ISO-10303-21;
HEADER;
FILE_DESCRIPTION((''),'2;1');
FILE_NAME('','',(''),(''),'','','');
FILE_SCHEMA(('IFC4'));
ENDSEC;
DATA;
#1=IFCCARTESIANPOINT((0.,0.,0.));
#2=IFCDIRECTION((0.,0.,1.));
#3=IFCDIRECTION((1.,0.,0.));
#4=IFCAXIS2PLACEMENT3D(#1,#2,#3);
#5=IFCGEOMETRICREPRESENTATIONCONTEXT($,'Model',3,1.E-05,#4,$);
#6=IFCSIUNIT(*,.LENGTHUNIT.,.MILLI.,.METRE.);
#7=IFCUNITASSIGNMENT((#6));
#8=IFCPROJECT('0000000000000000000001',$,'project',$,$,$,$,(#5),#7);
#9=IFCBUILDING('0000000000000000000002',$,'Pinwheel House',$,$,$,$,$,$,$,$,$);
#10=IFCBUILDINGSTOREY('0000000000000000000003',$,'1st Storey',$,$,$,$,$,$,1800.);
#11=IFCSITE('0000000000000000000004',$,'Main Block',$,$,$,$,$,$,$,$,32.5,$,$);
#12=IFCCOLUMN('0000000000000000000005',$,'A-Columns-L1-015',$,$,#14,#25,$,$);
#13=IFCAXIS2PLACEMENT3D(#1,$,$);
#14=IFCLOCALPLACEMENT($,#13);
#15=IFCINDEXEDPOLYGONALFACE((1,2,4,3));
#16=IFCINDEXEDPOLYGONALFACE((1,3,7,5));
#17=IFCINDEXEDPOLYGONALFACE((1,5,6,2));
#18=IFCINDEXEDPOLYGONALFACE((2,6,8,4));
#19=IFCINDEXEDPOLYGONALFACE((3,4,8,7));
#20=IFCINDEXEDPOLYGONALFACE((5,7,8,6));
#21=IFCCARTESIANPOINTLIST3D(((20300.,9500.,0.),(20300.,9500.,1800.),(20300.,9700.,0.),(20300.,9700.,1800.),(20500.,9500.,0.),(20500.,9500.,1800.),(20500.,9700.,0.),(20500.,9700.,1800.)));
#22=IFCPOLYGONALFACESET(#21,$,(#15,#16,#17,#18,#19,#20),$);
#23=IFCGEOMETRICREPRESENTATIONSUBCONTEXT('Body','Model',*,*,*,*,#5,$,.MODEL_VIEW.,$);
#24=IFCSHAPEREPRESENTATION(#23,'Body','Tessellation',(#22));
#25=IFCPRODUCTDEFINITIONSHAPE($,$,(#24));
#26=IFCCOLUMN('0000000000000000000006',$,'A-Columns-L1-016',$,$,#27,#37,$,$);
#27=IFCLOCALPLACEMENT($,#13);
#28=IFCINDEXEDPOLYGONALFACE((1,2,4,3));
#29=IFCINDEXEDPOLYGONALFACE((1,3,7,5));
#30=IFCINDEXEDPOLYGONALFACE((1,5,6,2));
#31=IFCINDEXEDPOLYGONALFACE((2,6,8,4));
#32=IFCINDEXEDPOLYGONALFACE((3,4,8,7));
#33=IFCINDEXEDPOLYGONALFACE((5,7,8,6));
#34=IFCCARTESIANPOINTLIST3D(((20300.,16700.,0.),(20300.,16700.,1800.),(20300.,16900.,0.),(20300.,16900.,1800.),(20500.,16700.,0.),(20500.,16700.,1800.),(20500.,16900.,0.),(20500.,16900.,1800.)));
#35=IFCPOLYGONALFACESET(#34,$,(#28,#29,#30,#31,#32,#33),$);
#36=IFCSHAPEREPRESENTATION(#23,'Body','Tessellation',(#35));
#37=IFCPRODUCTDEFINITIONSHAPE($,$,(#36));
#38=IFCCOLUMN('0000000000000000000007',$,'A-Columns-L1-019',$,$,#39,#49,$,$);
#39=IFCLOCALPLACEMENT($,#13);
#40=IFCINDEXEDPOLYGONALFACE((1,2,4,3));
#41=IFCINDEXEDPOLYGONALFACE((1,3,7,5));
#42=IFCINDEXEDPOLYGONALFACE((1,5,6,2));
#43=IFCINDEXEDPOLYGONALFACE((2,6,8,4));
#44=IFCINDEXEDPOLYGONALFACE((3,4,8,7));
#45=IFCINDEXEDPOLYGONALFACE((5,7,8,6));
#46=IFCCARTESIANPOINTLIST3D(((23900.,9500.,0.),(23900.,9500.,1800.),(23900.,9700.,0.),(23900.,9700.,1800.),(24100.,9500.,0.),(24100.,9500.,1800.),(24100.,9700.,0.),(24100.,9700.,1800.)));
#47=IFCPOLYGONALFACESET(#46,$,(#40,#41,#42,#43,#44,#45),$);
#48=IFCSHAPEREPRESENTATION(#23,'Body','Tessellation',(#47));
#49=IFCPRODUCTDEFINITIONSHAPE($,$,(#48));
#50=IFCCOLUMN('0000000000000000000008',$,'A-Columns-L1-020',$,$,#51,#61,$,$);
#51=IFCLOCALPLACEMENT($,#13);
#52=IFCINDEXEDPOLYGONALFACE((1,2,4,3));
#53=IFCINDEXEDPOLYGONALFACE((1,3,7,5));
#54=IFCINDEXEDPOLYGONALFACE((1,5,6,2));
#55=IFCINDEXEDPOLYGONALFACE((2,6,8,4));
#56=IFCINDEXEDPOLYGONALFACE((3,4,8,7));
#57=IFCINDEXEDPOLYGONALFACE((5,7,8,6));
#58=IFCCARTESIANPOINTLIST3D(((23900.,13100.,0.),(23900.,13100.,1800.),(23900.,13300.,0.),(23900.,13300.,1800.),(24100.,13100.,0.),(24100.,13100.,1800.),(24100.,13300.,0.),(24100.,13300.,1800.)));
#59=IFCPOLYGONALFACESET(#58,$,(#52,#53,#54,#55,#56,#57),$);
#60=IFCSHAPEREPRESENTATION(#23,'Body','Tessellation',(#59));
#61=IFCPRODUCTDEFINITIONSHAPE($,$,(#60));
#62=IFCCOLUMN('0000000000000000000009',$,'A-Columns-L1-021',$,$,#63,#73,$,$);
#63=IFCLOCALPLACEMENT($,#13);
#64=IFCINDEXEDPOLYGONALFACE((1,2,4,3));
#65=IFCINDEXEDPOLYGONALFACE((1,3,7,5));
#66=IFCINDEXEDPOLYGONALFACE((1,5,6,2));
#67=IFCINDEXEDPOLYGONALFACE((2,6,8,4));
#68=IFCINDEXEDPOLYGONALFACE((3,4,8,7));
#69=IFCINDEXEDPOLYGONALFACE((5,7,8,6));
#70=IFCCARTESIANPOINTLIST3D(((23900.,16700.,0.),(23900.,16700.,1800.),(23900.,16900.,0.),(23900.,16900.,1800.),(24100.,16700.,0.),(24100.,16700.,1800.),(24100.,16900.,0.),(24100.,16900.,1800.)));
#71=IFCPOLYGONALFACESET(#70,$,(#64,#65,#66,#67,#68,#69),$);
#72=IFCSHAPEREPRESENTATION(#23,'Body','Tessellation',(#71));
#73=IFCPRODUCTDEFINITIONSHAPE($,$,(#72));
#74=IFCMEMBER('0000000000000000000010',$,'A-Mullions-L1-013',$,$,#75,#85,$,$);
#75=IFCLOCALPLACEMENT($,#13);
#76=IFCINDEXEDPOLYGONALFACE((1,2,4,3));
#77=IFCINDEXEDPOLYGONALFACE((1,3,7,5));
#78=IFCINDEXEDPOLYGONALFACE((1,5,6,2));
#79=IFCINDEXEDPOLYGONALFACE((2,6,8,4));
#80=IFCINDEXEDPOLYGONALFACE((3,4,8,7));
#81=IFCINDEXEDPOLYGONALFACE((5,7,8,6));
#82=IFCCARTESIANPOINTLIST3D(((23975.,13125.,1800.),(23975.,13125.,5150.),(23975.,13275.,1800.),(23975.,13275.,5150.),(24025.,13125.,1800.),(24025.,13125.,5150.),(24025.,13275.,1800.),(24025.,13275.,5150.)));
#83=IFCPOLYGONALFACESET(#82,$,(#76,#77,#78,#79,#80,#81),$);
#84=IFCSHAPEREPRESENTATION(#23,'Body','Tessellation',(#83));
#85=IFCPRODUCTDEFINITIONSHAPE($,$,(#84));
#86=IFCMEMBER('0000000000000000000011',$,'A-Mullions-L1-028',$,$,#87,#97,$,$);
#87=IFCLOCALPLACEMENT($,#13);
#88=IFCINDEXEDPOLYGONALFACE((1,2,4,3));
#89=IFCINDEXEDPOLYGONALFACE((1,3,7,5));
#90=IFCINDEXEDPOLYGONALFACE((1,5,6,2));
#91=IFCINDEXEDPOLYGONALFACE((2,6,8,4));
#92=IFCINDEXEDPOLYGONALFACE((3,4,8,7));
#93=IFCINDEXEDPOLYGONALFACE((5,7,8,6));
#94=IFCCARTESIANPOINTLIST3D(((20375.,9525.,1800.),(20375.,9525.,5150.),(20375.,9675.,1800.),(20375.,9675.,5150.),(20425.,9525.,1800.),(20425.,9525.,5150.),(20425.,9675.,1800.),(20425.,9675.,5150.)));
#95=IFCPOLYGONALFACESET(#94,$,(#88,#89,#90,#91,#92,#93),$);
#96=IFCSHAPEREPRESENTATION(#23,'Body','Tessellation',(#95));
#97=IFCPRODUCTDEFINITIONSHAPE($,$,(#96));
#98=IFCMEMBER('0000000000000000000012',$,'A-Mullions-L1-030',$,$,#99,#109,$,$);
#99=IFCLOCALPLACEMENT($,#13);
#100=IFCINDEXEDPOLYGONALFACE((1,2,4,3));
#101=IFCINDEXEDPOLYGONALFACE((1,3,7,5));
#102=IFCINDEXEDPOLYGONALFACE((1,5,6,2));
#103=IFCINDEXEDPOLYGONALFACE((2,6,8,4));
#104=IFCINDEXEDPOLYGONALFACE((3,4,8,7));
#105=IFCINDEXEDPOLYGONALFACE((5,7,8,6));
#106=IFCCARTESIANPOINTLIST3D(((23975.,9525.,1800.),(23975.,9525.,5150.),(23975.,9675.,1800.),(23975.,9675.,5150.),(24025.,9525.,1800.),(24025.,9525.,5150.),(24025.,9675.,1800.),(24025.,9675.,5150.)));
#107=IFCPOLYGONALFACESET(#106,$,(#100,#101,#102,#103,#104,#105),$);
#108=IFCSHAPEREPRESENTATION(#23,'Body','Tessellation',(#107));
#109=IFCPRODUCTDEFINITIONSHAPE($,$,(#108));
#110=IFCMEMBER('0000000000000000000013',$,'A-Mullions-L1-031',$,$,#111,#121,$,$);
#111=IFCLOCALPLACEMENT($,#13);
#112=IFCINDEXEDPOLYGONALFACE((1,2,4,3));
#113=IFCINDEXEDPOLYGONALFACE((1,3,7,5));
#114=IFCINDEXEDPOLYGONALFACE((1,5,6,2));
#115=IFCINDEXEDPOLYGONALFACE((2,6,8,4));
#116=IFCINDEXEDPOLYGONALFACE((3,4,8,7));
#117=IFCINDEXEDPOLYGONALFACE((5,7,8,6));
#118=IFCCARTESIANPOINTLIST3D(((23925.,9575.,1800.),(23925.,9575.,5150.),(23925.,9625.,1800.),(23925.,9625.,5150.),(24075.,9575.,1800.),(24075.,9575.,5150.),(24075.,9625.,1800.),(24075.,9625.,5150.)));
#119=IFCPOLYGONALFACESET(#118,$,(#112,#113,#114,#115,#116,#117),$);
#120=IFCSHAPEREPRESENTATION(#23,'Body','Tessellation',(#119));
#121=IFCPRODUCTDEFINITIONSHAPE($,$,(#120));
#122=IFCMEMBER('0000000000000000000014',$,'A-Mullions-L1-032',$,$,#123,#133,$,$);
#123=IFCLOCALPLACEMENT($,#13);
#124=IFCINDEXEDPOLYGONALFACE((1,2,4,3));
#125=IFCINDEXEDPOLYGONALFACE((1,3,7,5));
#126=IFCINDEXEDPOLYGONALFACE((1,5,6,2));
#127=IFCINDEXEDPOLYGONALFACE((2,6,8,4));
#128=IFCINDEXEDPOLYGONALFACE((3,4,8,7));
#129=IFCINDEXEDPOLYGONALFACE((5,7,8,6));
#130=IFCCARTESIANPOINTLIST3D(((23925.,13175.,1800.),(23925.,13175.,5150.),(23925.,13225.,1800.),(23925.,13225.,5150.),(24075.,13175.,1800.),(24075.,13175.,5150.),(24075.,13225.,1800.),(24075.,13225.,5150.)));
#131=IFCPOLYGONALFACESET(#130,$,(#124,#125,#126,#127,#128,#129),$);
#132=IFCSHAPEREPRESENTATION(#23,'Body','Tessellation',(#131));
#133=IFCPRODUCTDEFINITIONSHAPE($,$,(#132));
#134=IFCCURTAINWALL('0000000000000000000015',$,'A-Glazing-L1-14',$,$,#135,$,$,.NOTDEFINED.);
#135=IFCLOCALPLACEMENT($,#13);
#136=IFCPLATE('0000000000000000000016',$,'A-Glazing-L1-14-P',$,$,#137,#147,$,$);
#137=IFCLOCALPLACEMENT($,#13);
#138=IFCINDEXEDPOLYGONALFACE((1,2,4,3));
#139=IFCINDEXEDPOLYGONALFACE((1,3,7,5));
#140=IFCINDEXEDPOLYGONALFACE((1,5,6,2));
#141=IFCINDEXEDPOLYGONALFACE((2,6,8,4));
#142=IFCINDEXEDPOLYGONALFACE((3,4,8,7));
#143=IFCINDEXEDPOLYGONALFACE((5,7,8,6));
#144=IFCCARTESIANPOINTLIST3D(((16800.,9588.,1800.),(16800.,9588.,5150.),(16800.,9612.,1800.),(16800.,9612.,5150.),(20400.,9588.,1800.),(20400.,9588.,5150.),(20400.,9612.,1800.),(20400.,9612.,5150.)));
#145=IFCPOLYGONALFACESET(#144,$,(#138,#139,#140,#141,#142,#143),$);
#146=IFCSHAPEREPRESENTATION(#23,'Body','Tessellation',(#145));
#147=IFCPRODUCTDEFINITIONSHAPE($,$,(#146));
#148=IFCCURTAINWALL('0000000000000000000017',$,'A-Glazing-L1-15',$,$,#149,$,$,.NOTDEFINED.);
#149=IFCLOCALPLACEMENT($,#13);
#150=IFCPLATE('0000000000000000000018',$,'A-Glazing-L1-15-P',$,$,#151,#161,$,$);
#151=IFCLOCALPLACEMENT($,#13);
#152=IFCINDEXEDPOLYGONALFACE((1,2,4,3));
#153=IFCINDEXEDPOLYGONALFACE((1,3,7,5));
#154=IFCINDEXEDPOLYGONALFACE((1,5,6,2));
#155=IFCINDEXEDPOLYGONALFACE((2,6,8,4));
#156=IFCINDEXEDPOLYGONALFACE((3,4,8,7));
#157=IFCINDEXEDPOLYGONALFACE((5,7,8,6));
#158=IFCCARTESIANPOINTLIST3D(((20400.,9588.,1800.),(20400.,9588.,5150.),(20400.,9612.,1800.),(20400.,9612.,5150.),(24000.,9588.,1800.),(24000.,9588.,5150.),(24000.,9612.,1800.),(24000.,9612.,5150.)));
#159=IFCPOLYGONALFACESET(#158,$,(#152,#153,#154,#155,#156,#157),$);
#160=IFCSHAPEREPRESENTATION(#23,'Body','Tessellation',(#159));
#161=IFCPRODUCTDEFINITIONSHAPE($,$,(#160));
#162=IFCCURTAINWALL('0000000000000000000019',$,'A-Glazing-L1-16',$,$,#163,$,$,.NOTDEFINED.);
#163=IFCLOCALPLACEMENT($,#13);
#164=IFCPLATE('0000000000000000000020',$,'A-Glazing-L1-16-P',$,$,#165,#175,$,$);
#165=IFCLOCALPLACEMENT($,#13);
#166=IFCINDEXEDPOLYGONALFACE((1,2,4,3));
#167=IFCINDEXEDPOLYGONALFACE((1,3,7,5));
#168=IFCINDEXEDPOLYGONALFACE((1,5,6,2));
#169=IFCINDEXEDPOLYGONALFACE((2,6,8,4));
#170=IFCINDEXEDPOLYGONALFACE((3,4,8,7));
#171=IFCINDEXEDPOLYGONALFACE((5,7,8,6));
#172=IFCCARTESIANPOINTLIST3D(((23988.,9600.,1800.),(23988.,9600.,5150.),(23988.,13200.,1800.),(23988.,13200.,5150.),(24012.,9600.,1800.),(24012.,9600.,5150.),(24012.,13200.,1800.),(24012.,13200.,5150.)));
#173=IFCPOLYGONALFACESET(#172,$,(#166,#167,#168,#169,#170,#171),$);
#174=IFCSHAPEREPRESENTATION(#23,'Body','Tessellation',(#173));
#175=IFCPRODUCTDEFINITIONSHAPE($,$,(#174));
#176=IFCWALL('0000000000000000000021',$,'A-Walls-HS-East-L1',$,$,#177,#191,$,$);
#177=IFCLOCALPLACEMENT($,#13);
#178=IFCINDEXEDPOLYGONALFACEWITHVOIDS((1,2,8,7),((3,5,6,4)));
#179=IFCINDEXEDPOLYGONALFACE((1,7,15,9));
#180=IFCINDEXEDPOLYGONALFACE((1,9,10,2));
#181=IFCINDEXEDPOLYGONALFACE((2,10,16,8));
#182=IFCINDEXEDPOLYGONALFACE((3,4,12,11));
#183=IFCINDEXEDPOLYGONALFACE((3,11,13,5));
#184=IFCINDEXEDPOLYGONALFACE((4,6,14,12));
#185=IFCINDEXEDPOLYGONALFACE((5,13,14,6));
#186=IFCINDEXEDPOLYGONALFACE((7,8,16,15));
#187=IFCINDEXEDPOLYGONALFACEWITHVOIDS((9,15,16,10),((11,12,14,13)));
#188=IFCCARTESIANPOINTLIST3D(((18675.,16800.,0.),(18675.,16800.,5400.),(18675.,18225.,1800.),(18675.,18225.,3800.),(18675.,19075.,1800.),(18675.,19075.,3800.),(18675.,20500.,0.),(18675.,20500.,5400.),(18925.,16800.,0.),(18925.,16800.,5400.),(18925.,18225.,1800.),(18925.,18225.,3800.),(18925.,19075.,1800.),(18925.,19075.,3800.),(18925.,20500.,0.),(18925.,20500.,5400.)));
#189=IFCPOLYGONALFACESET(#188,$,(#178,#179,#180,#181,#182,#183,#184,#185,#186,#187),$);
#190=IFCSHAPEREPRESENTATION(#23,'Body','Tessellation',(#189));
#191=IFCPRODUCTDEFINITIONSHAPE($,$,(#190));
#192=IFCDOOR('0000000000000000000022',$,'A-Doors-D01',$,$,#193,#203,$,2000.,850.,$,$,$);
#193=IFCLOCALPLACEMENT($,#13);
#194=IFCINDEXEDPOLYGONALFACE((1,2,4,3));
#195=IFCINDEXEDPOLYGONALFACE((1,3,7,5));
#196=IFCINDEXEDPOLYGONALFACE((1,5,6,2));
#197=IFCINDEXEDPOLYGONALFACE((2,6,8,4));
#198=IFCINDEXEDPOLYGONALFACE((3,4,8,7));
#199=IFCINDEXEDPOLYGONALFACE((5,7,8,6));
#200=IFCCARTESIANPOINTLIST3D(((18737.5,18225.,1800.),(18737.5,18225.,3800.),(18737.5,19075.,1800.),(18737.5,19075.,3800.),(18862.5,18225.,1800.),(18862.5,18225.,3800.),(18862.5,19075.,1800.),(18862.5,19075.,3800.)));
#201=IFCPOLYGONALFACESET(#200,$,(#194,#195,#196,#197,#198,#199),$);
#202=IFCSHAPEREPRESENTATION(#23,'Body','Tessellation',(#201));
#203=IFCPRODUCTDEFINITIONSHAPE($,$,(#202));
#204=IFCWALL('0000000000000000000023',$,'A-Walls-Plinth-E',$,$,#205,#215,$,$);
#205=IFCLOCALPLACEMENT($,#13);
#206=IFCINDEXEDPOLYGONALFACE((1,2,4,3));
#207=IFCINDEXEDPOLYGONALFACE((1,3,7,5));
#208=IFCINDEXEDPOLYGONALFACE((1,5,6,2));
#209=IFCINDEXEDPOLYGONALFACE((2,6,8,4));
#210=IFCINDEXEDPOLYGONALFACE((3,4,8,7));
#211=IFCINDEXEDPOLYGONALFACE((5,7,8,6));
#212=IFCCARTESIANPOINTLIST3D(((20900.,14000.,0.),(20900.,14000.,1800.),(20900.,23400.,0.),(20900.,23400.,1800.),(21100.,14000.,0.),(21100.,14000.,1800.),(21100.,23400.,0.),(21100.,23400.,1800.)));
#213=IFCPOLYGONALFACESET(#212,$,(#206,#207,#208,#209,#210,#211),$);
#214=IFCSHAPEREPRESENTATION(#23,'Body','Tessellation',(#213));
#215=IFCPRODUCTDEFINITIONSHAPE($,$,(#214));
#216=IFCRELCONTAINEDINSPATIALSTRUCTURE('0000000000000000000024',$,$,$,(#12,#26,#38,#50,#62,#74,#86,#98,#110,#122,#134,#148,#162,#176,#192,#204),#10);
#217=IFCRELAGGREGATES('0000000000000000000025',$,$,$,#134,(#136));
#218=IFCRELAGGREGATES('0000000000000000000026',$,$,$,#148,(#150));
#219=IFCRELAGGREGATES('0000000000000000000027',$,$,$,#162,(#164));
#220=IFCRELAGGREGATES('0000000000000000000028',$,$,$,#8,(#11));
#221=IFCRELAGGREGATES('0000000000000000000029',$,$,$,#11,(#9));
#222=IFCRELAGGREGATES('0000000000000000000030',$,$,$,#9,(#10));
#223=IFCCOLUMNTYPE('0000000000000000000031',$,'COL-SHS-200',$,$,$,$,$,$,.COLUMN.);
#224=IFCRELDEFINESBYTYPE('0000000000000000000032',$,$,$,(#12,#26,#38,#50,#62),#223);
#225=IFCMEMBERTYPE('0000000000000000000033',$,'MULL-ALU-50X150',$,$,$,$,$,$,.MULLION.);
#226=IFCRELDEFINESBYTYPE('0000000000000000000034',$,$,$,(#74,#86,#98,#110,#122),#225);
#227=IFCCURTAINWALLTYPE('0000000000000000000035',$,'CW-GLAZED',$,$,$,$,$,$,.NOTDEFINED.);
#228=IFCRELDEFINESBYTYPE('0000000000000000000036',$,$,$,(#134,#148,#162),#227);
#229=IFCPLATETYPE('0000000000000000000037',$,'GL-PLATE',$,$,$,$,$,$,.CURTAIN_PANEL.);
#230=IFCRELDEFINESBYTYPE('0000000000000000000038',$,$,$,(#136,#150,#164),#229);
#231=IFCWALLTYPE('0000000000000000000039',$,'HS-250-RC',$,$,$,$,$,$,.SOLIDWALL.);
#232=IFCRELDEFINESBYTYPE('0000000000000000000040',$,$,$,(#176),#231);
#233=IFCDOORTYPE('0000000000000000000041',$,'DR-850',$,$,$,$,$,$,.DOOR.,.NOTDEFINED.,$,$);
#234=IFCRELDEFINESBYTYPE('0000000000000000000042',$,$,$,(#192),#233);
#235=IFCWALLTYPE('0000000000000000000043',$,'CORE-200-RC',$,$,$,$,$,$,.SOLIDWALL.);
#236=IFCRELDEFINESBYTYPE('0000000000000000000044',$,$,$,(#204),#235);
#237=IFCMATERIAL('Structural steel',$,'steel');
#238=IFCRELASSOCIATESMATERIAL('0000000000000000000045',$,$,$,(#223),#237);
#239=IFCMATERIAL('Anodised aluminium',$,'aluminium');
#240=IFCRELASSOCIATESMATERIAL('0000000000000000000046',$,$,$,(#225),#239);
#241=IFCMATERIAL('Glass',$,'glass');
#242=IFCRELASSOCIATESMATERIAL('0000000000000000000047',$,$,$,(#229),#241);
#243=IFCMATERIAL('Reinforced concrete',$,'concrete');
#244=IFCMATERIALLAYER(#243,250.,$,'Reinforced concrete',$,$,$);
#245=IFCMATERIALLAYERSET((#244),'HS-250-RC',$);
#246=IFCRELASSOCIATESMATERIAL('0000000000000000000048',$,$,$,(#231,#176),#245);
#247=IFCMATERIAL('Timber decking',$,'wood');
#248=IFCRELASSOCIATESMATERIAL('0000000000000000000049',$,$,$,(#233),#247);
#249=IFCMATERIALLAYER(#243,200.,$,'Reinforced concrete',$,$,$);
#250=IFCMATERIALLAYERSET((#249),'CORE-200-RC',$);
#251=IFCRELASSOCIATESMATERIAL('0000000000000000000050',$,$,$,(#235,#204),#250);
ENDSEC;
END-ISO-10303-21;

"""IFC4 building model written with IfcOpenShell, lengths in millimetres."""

from ifc_helpers import new_model, si_unit, frame, origin_with_axes, place, context, subcontext, project, spatial, indexed_curve, outline, extrude, material, layer, layer_set, layer_usage, type_object, element, fill, aggregate, save


model = new_model("IFC4")

# Units and contexts
model_context = context("Model", 3, precision=1e-05, world=origin_with_axes())
body_context = subcontext(model_context, "Body", "Model", "MODEL_VIEW")
ifc_project = project(units=[si_unit("LENGTHUNIT", "METRE", prefix="MILLI")], contexts=[model_context])

# Site, building, storey
site = spatial("IfcSite", under=ifc_project, Name="Main Block", RefElevation=32.5)
building = spatial("IfcBuilding", under=site, Name="Pinwheel House")
storey = spatial("IfcBuildingStorey", under=building, Name="1st Storey", Elevation=1800.0)

# Columns
ifc_material_1 = material(Name="Structural steel", Category="steel")
column_type = type_object("IfcColumnType", Name="COL-SHS-200", PredefinedType="COLUMN", material=ifc_material_1)
for number, where, z_axis, x_axis, name in (
    (1, (20400.0, 9600.0, 0.0), (0.0, 0.0, 1.0), (1.0, 0.0, 0.0), "A-Columns-L1-015"),
    (2, (20400.0, 16800.0, 0.0), (0.0, 0.0, 1.0), (1.0, 0.0, 0.0), "A-Columns-L1-016"),
    (3, (24000.0, 9600.0, 0.0), (0.0, 0.0, 1.0), (1.0, 0.0, 0.0), "A-Columns-L1-019"),
    (4, (24000.0, 13200.0, 0.0), (0.0, 0.0, 1.0), (1.0, 0.0, 0.0), "A-Columns-L1-020"),
    (5, (24000.0, 16800.0, 0.0), (0.0, 0.0, 1.0), (1.0, 0.0, 0.0), "A-Columns-L1-021"),
):
    element("IfcColumn", number, at=place(None, frame(where, z_axis=z_axis, x_axis=x_axis)), inside=storey, type_object=column_type, Name=name, context=body_context, shape_type="SweptSolid", body=[
        extrude(outline(indexed_curve([(-100.0, -100.0), (100.0, -100.0), (100.0, 100.0), (-100.0, 100.0)])), None, (0.0, 0.0, 1.0), 1800.0),
    ])

# Members
ifc_material_2 = material(Name="Anodised aluminium", Category="aluminium")
member_type = type_object("IfcMemberType", Name="MULL-ALU-50X150", PredefinedType="MULLION", material=ifc_material_2)
for number, where, z_axis, x_axis, name in (
    (6, (24000.0, 13200.0, 1800.0), (0.0, 0.0, 1.0), (1.0, 0.0, 0.0), "A-Mullions-L1-013"),
    (7, (20400.0, 9600.0, 1800.0), (0.0, 0.0, 1.0), (1.0, 0.0, 0.0), "A-Mullions-L1-028"),
    (8, (24000.0, 9600.0, 1800.0), (0.0, 0.0, 1.0), (1.0, 0.0, 0.0), "A-Mullions-L1-030"),
    (9, (24000.0, 9600.0, 1800.0), (0.0, 0.0, 1.0), (0.0, 1.0, 0.0), "A-Mullions-L1-031"),
    (10, (24000.0, 13200.0, 1800.0), (0.0, 0.0, 1.0), (0.0, 1.0, 0.0), "A-Mullions-L1-032"),
):
    element("IfcMember", number, at=place(None, frame(where, z_axis=z_axis, x_axis=x_axis)), inside=storey, type_object=member_type, Name=name, context=body_context, shape_type="SweptSolid", body=[
        extrude(outline(indexed_curve([(-25.0, -75.0), (25.0, -75.0), (25.0, 75.0), (-25.0, 75.0)])), None, (0.0, 0.0, 1.0), 3350.0),
    ])

# Curtain walls, plates
curtain_wall_type = type_object("IfcCurtainWallType", Name="CW-GLAZED", PredefinedType="NOTDEFINED")
curtain_wall_1 = element("IfcCurtainWall", 11, inside=storey, type_object=curtain_wall_type, Name="A-Glazing-L1-14", PredefinedType="NOTDEFINED")
ifc_material_3 = material(Name="Glass", Category="glass")
plate_type = type_object("IfcPlateType", Name="GL-PLATE", PredefinedType="CURTAIN_PANEL", material=ifc_material_3)
plate_1_placement = place(None, frame((18600.0, 9600.0, 1800.0), z_axis=(0.0, 0.0, 1.0), x_axis=(1.0, 0.0, 0.0)))
plate_1 = element("IfcPlate", 12, at=plate_1_placement, type_object=plate_type, Name="A-Glazing-L1-14-P", context=body_context, shape_type="SweptSolid", body=[
    extrude(outline(indexed_curve([(-1800.0, -12.0), (1800.0, -12.0), (1800.0, 12.0), (-1800.0, 12.0)])), None, (0.0, 0.0, 1.0), 3350.0),
])
aggregate(curtain_wall_1, [plate_1])
curtain_wall_2 = element("IfcCurtainWall", 13, inside=storey, type_object=curtain_wall_type, Name="A-Glazing-L1-15", PredefinedType="NOTDEFINED")
plate_2_placement = place(None, frame((22200.0, 9600.0, 1800.0), z_axis=(0.0, 0.0, 1.0), x_axis=(1.0, 0.0, 0.0)))
plate_2 = element("IfcPlate", 14, at=plate_2_placement, type_object=plate_type, Name="A-Glazing-L1-15-P", context=body_context, shape_type="SweptSolid", body=[
    extrude(outline(indexed_curve([(-1800.0, -12.0), (1800.0, -12.0), (1800.0, 12.0), (-1800.0, 12.0)])), None, (0.0, 0.0, 1.0), 3350.0),
])
aggregate(curtain_wall_2, [plate_2])
curtain_wall_3 = element("IfcCurtainWall", 15, inside=storey, type_object=curtain_wall_type, Name="A-Glazing-L1-16", PredefinedType="NOTDEFINED")
plate_3_placement = place(None, frame((24000.0, 11400.0, 1800.0), z_axis=(0.0, 0.0, 1.0), x_axis=(0.0, 1.0, 0.0)))
plate_3 = element("IfcPlate", 16, at=plate_3_placement, type_object=plate_type, Name="A-Glazing-L1-16-P", context=body_context, shape_type="SweptSolid", body=[
    extrude(outline(indexed_curve([(-1800.0, -12.0), (1800.0, -12.0), (1800.0, 12.0), (-1800.0, 12.0)])), None, (0.0, 0.0, 1.0), 3350.0),
])
aggregate(curtain_wall_3, [plate_3])

# Wall, opening, door
ifc_material_4 = material(Name="Reinforced concrete", Category="concrete")
ifc_layer_1 = layer(ifc_material_4, 250.0, Name="Reinforced concrete")
ifc_layer_set_1 = layer_set([ifc_layer_1], Name="HS-250-RC")
ifc_layer_usage_1 = layer_usage(ifc_layer_set_1, "AXIS2", "POSITIVE", 0.0)
wall_type_1 = type_object("IfcWallType", Name="HS-250-RC", PredefinedType="SOLIDWALL", material=ifc_layer_set_1)
wall_1_placement = place(None, frame((18925.0, 16800.0, 0.0), z_axis=(0.0, 0.0, 1.0), x_axis=(0.0, 1.0, 0.0)))
wall_1 = element("IfcWall", 17, at=wall_1_placement, inside=storey, type_object=wall_type_1, material=ifc_layer_usage_1, Name="A-Walls-HS-East-L1", context=body_context, shape_type="SweptSolid", body=[
    extrude(outline(indexed_curve([(0.0, 0.0), (0.0, 250.0), (3700.0, 250.0), (3700.0, 0.0), (0.0, 0.0)], self_intersect=False)), origin_with_axes(), (0.0, 0.0, 1.0), 5400.0),
])
opening_1_placement = place(wall_1_placement, frame((1850.0, 125.0, 1800.0), z_axis=(0.0, 0.0, 1.0), x_axis=(1.0, 0.0, 0.0)))
opening_1 = element("IfcOpeningElement", 18, at=opening_1_placement, cuts=wall_1, PredefinedType="OPENING", context=body_context, shape_type="SweptSolid", body=[
    extrude(outline(indexed_curve([(-425.0, -175.0), (425.0, -175.0), (425.0, 175.0), (-425.0, 175.0)])), None, (0.0, 0.0, 1.0), 2000.0),
])
ifc_material_5 = material(Name="Timber decking", Category="wood")
door_type_1 = type_object("IfcDoorType", Name="DR-850", OperationType="NOTDEFINED", PredefinedType="DOOR", material=ifc_material_5)
door_1_placement = place(None, frame((18800.0, 18650.0, 1800.0), z_axis=(0.0, 0.0, 1.0), x_axis=(0.0, 1.0, 0.0)))
door_1 = element("IfcDoor", 19, at=door_1_placement, inside=storey, type_object=door_type_1, Name="A-Doors-D01", OverallHeight=2000.0, OverallWidth=850.0, context=body_context, shape_type="SweptSolid", body=[
    extrude(outline(indexed_curve([(-425.0, -62.5), (425.0, -62.5), (425.0, 62.5), (-425.0, 62.5)])), None, (0.0, 0.0, 1.0), 2000.0),
])
fill(opening_1, door_1)

# Wall
ifc_layer_2 = layer(ifc_material_4, 200.0, Name="Reinforced concrete")
ifc_layer_set_2 = layer_set([ifc_layer_2], Name="CORE-200-RC")
ifc_layer_usage_2 = layer_usage(ifc_layer_set_2, "AXIS2", "POSITIVE", 0.0)
wall_type_2 = type_object("IfcWallType", Name="CORE-200-RC", PredefinedType="SOLIDWALL", material=ifc_layer_set_2)
wall_2_placement = place(None, frame((21100.0, 14000.0, 0.0), z_axis=(0.0, 0.0, 1.0), x_axis=(0.0, 1.0, 0.0)))
element("IfcWall", 20, at=wall_2_placement, inside=storey, type_object=wall_type_2, material=ifc_layer_usage_2, Name="A-Walls-Plinth-E", context=body_context, shape_type="SweptSolid", body=[
    extrude(outline(indexed_curve([(0.0, 0.0), (0.0, 200.0), (9400.0, 200.0), (9400.0, 0.0), (0.0, 0.0)], self_intersect=False)), origin_with_axes(), (0.0, 0.0, 1.0), 1800.0),
])

save(model, "model.ifc")
